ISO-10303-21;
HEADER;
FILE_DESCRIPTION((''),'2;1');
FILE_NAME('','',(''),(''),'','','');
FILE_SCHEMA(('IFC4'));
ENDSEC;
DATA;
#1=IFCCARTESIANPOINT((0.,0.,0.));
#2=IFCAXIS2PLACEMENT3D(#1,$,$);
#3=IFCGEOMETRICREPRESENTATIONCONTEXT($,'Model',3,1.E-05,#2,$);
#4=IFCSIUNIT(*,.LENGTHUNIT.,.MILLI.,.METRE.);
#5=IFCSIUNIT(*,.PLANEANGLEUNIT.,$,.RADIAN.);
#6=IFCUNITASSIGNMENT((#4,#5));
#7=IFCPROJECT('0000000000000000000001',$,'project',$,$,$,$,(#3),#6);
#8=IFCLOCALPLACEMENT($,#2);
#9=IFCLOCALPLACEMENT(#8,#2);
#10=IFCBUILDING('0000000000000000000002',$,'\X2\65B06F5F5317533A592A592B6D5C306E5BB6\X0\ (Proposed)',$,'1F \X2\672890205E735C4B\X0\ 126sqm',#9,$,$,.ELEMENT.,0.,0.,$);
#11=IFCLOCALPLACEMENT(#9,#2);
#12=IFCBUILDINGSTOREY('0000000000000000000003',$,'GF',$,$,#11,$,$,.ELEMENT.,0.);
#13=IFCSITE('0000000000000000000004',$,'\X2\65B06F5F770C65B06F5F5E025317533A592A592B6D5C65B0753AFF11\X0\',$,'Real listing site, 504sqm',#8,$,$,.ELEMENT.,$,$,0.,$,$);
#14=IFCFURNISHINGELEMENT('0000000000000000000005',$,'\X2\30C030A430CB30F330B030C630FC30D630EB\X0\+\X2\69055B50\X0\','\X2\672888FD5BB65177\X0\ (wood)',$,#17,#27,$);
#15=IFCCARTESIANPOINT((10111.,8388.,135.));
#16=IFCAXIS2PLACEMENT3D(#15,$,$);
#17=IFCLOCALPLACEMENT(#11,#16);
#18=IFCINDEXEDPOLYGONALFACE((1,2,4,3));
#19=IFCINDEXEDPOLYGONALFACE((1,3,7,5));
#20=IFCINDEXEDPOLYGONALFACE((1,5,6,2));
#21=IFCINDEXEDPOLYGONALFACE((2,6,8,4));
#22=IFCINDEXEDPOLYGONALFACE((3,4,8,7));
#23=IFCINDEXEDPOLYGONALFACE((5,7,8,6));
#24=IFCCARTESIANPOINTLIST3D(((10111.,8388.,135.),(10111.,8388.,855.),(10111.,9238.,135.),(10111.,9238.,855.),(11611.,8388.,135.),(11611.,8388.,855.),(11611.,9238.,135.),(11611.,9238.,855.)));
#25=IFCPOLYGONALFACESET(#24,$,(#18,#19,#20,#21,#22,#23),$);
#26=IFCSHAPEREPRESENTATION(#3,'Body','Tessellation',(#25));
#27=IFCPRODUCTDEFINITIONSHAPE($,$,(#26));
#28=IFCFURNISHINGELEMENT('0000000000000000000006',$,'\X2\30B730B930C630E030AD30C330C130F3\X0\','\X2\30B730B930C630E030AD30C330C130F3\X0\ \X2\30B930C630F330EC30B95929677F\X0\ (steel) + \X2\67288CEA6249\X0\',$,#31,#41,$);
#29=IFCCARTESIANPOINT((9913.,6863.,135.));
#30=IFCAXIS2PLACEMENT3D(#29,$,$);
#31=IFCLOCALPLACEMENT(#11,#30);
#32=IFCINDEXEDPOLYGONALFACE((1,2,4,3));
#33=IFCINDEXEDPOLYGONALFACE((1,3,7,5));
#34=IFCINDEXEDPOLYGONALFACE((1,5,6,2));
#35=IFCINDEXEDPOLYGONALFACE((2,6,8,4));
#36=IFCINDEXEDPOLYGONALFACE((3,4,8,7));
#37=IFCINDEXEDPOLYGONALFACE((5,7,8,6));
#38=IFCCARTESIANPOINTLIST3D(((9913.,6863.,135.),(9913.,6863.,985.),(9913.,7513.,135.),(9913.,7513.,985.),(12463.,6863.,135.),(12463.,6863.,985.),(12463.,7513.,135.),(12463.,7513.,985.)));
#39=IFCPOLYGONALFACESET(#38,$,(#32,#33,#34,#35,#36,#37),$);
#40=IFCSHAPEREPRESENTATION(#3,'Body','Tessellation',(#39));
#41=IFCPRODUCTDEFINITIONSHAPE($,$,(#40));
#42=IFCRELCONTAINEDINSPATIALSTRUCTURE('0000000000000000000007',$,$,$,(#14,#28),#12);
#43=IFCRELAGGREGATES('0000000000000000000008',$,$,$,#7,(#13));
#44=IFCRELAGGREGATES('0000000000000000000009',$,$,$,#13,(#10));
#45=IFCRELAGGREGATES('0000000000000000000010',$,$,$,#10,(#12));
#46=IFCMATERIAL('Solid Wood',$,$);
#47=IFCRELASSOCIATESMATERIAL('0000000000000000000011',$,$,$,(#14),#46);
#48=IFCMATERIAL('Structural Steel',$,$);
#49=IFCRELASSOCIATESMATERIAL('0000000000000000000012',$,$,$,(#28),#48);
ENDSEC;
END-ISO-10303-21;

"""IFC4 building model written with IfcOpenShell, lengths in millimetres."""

from ifc_helpers import new_model, si_unit, frame, frame_2d, origin, place, context, project, spatial, rectangle, extrude, material, element, save


model = new_model("IFC4")

# Units and contexts
model_context = context("Model", 3, precision=1e-05, world=origin())
ifc_project = project(units=[si_unit("LENGTHUNIT", "METRE", prefix="MILLI"), si_unit("PLANEANGLEUNIT", "RADIAN")], contexts=[model_context])

# Site, building, storey
site_placement = place(None, origin())
site = spatial("IfcSite", under=ifc_project, at=site_placement, Name="新潟県新潟市北区太夫浜新町１", ObjectType="Real listing site, 504sqm", CompositionType="ELEMENT", RefElevation=0.0)
building_placement = place(site_placement, origin())
building = spatial("IfcBuilding", under=site, at=building_placement, Name="新潟北区太夫浜の家 (Proposed)", ObjectType="1F 木造平屋 126sqm", CompositionType="ELEMENT", ElevationOfRefHeight=0.0, ElevationOfTerrain=0.0)
storey_placement = place(building_placement, origin())
storey = spatial("IfcBuildingStorey", under=building, at=storey_placement, Name="GF", CompositionType="ELEMENT", Elevation=0.0)

# Shared definitions
ifc_material_1 = material(Name="Solid Wood")

# Shared definitions
ifc_material_2 = material(Name="Structural Steel")

# Furnishing elements
furnishing_1_placement = place(storey_placement, frame((10111.0, 8388.0, 135.0)))
element("IfcFurnishingElement", 1, at=furnishing_1_placement, inside=storey, material=ifc_material_1, Name="ダイニングテーブル+椅子", Description="木製家具 (wood)", context=model_context, shape_type="SweptSolid", body=[
    extrude(rectangle(XDim=1500.0, YDim=850.0, at=frame_2d((750.0, 425.0))), frame((10111.0, 8388.0, 135.0)), (0.0, 0.0, 1.0), 720.0),
])
furnishing_2_placement = place(storey_placement, frame((9913.0, 6863.0, 135.0)))
element("IfcFurnishingElement", 2, at=furnishing_2_placement, inside=storey, material=ifc_material_2, Name="システムキッチン", Description="システムキッチン ステンレス天板 (steel) + 木質扉", context=model_context, shape_type="SweptSolid", body=[
    extrude(rectangle(XDim=2550.0, YDim=650.0, at=frame_2d((1275.0, 325.0))), frame((9913.0, 6863.0, 135.0)), (0.0, 0.0, 1.0), 850.0),
])

save(model, "model.ifc")
